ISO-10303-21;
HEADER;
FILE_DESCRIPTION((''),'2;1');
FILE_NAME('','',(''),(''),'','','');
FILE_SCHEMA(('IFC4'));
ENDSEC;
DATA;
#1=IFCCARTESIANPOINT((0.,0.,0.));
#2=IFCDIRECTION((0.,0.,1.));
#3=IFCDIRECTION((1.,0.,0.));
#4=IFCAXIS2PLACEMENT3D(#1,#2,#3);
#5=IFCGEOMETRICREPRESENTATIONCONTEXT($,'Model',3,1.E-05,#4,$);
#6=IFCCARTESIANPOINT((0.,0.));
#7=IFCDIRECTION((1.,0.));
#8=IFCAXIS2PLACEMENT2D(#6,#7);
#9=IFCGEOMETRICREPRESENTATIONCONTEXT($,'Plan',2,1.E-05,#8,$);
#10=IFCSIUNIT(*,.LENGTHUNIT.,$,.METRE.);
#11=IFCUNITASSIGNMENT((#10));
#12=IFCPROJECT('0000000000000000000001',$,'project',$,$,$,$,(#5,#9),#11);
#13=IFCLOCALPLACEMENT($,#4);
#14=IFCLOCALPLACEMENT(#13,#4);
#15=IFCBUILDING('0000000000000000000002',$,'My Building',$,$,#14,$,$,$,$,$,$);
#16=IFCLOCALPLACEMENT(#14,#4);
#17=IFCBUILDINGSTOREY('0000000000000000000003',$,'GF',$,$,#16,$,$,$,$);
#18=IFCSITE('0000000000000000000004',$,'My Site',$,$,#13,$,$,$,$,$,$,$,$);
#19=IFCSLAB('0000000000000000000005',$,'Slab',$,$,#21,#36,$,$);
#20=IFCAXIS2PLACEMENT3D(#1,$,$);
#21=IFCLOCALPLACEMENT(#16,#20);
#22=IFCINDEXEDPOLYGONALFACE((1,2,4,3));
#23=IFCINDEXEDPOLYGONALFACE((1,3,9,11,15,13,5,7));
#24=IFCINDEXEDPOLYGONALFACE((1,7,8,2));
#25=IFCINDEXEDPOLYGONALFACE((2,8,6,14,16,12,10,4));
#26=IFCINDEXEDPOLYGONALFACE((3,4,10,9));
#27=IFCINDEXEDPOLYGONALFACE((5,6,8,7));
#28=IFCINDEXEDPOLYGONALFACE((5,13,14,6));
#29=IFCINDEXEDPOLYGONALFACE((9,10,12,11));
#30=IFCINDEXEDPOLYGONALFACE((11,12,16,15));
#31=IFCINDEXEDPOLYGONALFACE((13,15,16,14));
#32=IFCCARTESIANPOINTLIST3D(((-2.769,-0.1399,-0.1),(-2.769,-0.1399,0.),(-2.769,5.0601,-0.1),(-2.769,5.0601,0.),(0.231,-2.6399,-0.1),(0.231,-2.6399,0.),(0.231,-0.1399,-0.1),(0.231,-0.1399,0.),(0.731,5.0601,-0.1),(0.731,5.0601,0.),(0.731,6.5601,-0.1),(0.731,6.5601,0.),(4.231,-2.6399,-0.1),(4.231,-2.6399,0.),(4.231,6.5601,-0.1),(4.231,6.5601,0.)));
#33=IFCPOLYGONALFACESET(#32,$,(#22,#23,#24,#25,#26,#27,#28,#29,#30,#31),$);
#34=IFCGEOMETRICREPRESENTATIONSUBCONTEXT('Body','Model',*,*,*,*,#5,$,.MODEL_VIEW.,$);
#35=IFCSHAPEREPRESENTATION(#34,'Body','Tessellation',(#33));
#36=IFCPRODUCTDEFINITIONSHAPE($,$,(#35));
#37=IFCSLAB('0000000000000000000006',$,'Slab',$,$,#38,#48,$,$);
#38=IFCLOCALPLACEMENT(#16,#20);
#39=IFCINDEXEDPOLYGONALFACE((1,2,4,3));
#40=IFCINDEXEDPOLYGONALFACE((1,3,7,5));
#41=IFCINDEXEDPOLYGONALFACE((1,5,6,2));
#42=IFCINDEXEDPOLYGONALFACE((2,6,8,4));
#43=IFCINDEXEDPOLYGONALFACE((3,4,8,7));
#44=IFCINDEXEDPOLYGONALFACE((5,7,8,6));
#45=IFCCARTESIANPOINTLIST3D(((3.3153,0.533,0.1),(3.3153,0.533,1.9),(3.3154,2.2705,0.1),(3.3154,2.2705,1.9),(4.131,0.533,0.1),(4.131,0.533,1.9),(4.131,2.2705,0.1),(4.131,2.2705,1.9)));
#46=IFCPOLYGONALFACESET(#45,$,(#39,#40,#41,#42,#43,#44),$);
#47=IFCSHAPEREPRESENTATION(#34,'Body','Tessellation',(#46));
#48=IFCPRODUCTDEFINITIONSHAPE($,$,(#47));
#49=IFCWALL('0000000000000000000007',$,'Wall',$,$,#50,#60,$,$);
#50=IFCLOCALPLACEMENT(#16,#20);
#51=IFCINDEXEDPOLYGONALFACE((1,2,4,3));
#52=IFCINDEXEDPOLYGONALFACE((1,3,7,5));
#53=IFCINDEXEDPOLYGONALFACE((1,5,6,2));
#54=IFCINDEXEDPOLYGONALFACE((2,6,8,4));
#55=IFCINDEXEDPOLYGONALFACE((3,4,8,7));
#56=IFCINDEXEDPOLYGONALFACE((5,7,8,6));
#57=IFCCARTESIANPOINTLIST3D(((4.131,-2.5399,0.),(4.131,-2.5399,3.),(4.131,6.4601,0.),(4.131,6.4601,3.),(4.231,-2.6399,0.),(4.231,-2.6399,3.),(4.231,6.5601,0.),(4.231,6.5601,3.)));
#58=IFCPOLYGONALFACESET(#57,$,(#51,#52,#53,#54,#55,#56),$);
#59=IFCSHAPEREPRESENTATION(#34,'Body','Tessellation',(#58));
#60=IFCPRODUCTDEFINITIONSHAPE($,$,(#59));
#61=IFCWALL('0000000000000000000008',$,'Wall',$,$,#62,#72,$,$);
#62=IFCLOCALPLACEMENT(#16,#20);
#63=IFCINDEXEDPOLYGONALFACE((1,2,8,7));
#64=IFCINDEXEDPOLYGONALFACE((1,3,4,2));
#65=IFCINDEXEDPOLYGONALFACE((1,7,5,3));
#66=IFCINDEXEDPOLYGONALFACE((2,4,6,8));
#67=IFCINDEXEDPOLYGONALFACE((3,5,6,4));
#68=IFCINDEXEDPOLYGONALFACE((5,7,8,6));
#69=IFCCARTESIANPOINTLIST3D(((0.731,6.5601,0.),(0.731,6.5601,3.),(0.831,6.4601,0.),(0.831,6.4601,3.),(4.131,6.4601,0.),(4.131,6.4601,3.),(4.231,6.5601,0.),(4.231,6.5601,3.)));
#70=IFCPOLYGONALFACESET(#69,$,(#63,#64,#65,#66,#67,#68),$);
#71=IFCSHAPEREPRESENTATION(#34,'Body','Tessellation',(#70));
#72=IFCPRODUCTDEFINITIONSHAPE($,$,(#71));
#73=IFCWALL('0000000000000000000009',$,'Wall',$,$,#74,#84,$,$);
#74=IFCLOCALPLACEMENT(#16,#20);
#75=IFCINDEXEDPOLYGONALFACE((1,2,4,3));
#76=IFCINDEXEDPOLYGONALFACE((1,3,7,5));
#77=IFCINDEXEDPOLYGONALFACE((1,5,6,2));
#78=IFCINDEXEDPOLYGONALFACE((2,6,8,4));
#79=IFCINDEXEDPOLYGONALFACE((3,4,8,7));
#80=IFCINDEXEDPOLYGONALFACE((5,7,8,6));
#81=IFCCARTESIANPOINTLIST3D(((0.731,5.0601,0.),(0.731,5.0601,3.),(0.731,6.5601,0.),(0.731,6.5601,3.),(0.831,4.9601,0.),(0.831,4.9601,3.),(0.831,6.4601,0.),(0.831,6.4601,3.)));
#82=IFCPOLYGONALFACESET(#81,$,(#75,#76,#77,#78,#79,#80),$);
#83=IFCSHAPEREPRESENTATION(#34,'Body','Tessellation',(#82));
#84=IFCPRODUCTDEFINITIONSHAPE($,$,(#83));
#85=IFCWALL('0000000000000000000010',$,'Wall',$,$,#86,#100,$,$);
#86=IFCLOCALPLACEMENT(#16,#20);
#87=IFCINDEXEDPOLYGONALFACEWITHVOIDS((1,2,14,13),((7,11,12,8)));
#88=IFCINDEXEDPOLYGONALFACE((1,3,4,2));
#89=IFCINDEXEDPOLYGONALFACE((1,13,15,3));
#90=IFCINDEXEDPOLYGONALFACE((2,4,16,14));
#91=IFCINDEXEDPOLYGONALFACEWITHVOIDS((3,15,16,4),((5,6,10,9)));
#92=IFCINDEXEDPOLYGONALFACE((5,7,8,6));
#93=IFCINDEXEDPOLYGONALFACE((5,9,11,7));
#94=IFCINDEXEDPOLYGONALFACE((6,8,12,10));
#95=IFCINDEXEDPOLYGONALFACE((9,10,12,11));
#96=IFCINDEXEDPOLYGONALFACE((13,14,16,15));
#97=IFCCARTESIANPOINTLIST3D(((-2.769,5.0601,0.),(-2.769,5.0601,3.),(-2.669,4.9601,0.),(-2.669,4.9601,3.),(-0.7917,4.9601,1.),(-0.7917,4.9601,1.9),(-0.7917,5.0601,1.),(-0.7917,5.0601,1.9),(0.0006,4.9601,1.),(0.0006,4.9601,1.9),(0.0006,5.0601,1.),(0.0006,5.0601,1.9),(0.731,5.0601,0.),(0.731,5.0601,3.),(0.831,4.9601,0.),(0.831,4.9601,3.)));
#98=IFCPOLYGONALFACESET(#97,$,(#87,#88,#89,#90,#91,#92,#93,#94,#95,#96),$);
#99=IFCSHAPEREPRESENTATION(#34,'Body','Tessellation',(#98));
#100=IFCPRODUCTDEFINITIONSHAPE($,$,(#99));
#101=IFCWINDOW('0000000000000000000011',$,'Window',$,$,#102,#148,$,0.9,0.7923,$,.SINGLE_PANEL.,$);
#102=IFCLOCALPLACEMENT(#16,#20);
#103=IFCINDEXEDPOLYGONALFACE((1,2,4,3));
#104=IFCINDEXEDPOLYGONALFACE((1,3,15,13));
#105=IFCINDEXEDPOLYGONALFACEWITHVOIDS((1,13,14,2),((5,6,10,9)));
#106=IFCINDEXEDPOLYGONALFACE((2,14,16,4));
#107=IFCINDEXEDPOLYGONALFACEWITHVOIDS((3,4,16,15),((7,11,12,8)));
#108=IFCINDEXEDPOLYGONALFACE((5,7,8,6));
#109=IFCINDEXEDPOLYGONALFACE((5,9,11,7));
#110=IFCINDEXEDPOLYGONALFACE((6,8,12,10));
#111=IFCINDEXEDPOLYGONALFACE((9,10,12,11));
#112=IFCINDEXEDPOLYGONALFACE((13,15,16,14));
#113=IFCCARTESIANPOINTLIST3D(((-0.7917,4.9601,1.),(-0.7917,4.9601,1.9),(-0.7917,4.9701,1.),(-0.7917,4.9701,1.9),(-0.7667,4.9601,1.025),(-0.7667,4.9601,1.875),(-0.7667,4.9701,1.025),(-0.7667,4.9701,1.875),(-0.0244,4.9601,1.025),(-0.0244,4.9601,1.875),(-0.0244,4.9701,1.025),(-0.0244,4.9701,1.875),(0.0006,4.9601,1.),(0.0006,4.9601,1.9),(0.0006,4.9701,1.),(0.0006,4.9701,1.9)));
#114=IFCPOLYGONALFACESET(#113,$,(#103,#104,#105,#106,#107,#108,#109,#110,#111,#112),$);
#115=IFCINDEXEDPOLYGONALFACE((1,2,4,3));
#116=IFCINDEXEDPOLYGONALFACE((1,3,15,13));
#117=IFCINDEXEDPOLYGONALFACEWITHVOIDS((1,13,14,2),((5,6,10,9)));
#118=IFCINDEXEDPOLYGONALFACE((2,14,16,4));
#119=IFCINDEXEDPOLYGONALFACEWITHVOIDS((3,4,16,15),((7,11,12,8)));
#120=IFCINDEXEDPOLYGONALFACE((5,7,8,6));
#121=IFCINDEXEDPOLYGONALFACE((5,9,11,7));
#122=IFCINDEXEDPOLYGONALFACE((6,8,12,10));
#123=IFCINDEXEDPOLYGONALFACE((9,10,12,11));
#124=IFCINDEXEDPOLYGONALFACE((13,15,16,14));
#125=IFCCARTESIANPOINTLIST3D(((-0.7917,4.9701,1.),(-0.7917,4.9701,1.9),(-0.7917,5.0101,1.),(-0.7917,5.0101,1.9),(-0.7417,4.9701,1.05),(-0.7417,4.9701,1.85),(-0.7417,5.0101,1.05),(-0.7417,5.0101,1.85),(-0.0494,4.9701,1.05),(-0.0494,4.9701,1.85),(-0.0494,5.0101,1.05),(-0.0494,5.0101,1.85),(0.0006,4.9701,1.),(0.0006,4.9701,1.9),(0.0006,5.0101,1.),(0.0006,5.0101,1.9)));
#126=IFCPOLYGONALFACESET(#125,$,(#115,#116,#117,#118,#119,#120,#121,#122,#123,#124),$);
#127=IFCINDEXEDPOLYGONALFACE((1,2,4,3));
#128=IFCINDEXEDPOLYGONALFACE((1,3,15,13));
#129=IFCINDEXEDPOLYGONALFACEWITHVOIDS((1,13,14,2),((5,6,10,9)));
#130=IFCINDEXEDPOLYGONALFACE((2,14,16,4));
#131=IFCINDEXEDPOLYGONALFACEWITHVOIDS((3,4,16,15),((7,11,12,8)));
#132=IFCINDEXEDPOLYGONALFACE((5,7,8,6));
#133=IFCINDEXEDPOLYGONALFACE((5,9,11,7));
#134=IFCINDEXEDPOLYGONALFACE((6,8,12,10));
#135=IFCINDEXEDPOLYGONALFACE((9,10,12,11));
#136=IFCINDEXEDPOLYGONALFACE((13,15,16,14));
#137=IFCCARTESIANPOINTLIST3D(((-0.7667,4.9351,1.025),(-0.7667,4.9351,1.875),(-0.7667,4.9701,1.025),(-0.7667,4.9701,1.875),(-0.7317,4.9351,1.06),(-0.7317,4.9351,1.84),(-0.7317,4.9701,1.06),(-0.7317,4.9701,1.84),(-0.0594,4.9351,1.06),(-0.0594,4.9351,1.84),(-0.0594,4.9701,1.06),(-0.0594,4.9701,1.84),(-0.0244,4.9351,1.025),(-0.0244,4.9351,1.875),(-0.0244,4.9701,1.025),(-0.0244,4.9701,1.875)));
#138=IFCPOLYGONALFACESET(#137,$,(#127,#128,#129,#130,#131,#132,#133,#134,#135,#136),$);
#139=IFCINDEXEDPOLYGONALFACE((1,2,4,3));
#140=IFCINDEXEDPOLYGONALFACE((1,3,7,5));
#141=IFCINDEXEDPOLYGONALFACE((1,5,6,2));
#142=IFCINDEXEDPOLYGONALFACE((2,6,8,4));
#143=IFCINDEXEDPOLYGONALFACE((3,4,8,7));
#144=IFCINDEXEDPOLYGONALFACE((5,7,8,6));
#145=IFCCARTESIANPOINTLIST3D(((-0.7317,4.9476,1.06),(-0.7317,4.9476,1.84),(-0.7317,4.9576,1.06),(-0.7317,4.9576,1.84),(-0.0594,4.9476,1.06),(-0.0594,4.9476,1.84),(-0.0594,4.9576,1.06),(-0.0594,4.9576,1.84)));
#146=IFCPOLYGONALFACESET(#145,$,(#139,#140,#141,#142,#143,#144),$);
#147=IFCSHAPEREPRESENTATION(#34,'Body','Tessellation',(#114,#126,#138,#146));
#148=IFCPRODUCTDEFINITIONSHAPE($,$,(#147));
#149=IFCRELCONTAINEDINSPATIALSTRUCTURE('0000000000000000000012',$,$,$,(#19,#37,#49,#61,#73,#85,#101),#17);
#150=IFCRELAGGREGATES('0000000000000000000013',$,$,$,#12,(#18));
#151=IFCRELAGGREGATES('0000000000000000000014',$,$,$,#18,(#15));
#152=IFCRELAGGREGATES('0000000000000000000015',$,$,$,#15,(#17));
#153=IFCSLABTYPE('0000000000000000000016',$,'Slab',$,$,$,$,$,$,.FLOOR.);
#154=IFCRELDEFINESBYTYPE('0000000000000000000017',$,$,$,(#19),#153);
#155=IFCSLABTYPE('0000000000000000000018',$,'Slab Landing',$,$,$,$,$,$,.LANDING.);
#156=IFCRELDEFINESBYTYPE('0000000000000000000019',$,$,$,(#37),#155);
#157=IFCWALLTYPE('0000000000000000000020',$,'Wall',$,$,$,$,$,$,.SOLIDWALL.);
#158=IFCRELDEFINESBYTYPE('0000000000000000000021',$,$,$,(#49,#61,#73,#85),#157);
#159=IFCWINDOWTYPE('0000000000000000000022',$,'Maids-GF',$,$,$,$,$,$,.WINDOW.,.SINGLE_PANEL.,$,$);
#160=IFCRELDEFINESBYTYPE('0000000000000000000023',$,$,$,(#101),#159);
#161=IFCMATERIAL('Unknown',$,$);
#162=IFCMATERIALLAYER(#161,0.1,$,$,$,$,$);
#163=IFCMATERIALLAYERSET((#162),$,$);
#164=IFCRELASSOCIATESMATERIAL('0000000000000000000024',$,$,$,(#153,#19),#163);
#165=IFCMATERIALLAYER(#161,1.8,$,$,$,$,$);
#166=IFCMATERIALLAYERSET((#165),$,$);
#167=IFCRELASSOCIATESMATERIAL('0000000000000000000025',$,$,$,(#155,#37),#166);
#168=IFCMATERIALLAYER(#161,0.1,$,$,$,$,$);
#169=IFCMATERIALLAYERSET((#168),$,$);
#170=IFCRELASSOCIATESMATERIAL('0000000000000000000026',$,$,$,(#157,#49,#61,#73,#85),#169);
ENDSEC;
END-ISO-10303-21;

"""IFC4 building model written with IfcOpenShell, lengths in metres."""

from ifc_helpers import new_model, entity, si_unit, frame, origin_with_axes, origin_2d_with_axis, place, context, subcontext, project, spatial, line, indexed_curve, outline, extrude, shape, source, transform, mapped, material, layer, layer_set, layer_usage, type_object, type_shapes, element, fill, save


model = new_model("IFC4")

# Units and contexts
model_context = context("Model", 3, precision=1e-05, world=origin_with_axes())
plan_context = context("Plan", 2, precision=1e-05, world=origin_2d_with_axis())
body_context_1 = subcontext(model_context, "Body", "Model", "MODEL_VIEW")
body_context_2 = subcontext(plan_context, "Body", "Plan", "PLAN_VIEW")
ifc_project = project(units=[si_unit("LENGTHUNIT", "METRE")], contexts=[model_context, plan_context])

# Site, building, storey
site_placement = place(None, origin_with_axes())
site = spatial("IfcSite", under=ifc_project, at=site_placement, Name="My Site")
building_placement = place(site_placement, origin_with_axes())
building = spatial("IfcBuilding", under=site, at=building_placement, Name="My Building")
storey_placement = place(building_placement, origin_with_axes())
storey = spatial("IfcBuildingStorey", under=building, at=storey_placement, Name="GF")

# Slabs
ifc_material_1 = material(Name="Unknown")
ifc_layer_1 = layer(ifc_material_1, 0.1)
ifc_layer_set_1 = layer_set([ifc_layer_1])
ifc_layer_usage_1 = layer_usage(ifc_layer_set_1, "AXIS3", "POSITIVE", -0.1)
slab_type_1 = type_object("IfcSlabType", Name="Slab", PredefinedType="FLOOR", material=ifc_layer_set_1)
slab_1_placement = place(storey_placement, frame((4.231, 6.5601, 0.0), z_axis=(0.0, 0.0, 1.0), x_axis=(1.0, 0.0, 0.0)))
element("IfcSlab", 1, at=slab_1_placement, inside=storey, type_object=slab_type_1, material=ifc_layer_usage_1, Name="Slab", context=body_context_1, shape_type="SweptSolid", body=[
    extrude(outline(indexed_curve([(0.0, 0.0), (-3.5, 0.0), (-3.5, -1.5), (-7.0, -1.5), (-7.0, -6.7), (-4.0, -6.7), (-4.0, -9.2), (0.0, -9.2), (0.0, 0.0)])), frame((0.0, 0.0, -0.1), z_axis=(0.0, 0.0, 1.0), x_axis=(1.0, 0.0, 0.0)), (0.0, 0.0, 1.0), 0.1),
])
ifc_layer_2 = layer(ifc_material_1, 1.8)
ifc_layer_set_2 = layer_set([ifc_layer_2])
ifc_layer_usage_2 = layer_usage(ifc_layer_set_2, "AXIS3", "POSITIVE", -0.1)
slab_type_2 = type_object("IfcSlabType", Name="Slab Landing", PredefinedType="LANDING", material=ifc_layer_set_2)
slab_2_placement = place(storey_placement, frame((3.3153, 0.533, 0.2), z_axis=(0.0, 0.0, 1.0), x_axis=(1.0, 0.0, 0.0)))
element("IfcSlab", 2, at=slab_2_placement, inside=storey, type_object=slab_type_2, material=ifc_layer_usage_2, Name="Slab", context=body_context_1, shape_type="SweptSolid", body=[
    extrude(outline(indexed_curve([(0.0, 1.7375), (0.8156, 1.7375), (0.8156, 0.0), (0.0, 0.0), (0.0, 1.7375)])), frame((0.0, 0.0, -0.1), z_axis=(0.0, 0.0, 1.0), x_axis=(1.0, 0.0, 0.0)), (0.0, 0.0, 1.0), 1.8),
])

# Shared definitions
ifc_layer_3 = layer(ifc_material_1, 0.1)
ifc_layer_set_3 = layer_set([ifc_layer_3])
wall_type = type_object("IfcWallType", Name="Wall", PredefinedType="SOLIDWALL", material=ifc_layer_set_3)

# Walls
ifc_layer_usage_3 = layer_usage(ifc_layer_set_3, "AXIS2", "POSITIVE", 0.0)
wall_1_placement = place(storey_placement, frame((4.231, -2.6399, 0.0), z_axis=(0.0, 0.0, 1.0), x_axis=(0.0, 1.0, 0.0)))
element("IfcWall", 3, at=wall_1_placement, inside=storey, type_object=wall_type, material=ifc_layer_usage_3, Name="Wall", context=body_context_1, shape_type="SweptSolid", body=[
    extrude(outline(indexed_curve([(0.0, 0.0), (0.1, 0.1), (9.1, 0.1), (9.2, 0.0)], segments=[line(1, 2, 3, 4, 1)])), origin_with_axes(), (0.0, 0.0, 1.0), 3.0),
])
ifc_layer_usage_4 = layer_usage(ifc_layer_set_3, "AXIS2", "POSITIVE", 0.0)
wall_2_placement = place(storey_placement, frame((4.231, 6.5601, 0.0), z_axis=(0.0, 0.0, 1.0), x_axis=(-1.0, 0.0, 0.0)))
element("IfcWall", 4, at=wall_2_placement, inside=storey, type_object=wall_type, material=ifc_layer_usage_4, Name="Wall", context=body_context_1, shape_type="SweptSolid", body=[
    extrude(outline(indexed_curve([(0.0, 0.0), (0.1, 0.1), (3.4, 0.1), (3.5, 0.0)], segments=[line(1, 2, 3, 4, 1)])), origin_with_axes(), (0.0, 0.0, 1.0), 3.0),
])
ifc_layer_usage_5 = layer_usage(ifc_layer_set_3, "AXIS2", "POSITIVE", 0.0)
wall_3_placement = place(storey_placement, frame((0.731, 6.5601, 0.0), z_axis=(0.0, 0.0, 1.0), x_axis=(0.0, -1.0, 0.0)))
element("IfcWall", 5, at=wall_3_placement, inside=storey, type_object=wall_type, material=ifc_layer_usage_5, Name="Wall", context=body_context_1, shape_type="SweptSolid", body=[
    extrude(outline(indexed_curve([(0.0, 0.0), (0.1, 0.1), (1.6, 0.1), (1.5, 0.0)], segments=[line(1, 2, 3, 4, 1)])), origin_with_axes(), (0.0, 0.0, 1.0), 3.0),
])

# Wall, opening, window
ifc_layer_usage_6 = layer_usage(ifc_layer_set_3, "AXIS2", "POSITIVE", 0.0)
wall_4_placement = place(storey_placement, frame((0.731, 5.0601, 0.0), z_axis=(0.0, 0.0, 1.0), x_axis=(-1.0, 0.0, 0.0)))
wall_4 = element("IfcWall", 6, at=wall_4_placement, inside=storey, type_object=wall_type, material=ifc_layer_usage_6, Name="Wall", context=body_context_1, shape_type="SweptSolid", body=[
    extrude(outline(indexed_curve([(0.0, 0.0), (-0.1, 0.1), (3.4, 0.1), (3.5, 0.0)], segments=[line(1, 2, 3, 4, 1)])), origin_with_axes(), (0.0, 0.0, 1.0), 3.0),
])
shared_shape_1 = source(origin_with_axes(), body_context_1, "Body", "SweptSolid", [
    extrude(outline(indexed_curve([(0.0, 0.0), (0.7923, 0.0), (0.7923, 0.9), (0.0, 0.9)], segments=[line(1, 2, 3, 4, 1)])), frame((0.0, -0.6, 0.0), z_axis=(0.0, -1.0, 0.0), x_axis=(1.0, 0.0, 0.0)), (0.0, 0.0, -1.0), 1.2),
])
opening_1_placement = place(wall_4_placement, frame((0.7304, 0.0, 1.0), z_axis=(0.0, 0.0, 1.0), x_axis=(1.0, 0.0, 0.0)))
opening_1 = element("IfcOpeningElement", 7, at=opening_1_placement, cuts=wall_4, PredefinedType="OPENING", context=body_context_1, shape_type="MappedRepresentation", body=[
    mapped(shared_shape_1, transform((0.0, 0.0, 0.0), x_axis=(1.0, 0.0, 0.0), y_axis=(0.0, 1.0, 0.0), z_axis=(0.0, 0.0, 1.0), scale=1.0)),
])
window_type_1 = type_object("IfcWindowType", Name="Maids-GF", PartitioningType="SINGLE_PANEL", PredefinedType="WINDOW")
shared_shape_2 = source(origin_with_axes(), body_context_1, "Body", "SweptSolid", [
    extrude(outline(indexed_curve([(0.0, 0.0), (0.7923, 0.0), (0.7923, 0.9), (0.0, 0.9)], segments=[line(1, 2, 3, 4, 1)]), holes=[indexed_curve([(0.025, 0.025), (0.7673, 0.025), (0.7673, 0.875), (0.025, 0.875)], segments=[line(1, 2, 3, 4, 1)])]), frame((0.0, 0.09, 0.0), z_axis=(0.0, -1.0, 0.0), x_axis=(1.0, 0.0, 0.0)), (0.0, 0.0, -1.0), 0.01),
    extrude(outline(indexed_curve([(0.0, 0.0), (0.7923, 0.0), (0.7923, 0.9), (0.0, 0.9)], segments=[line(1, 2, 3, 4, 1)]), holes=[indexed_curve([(0.05, 0.05), (0.7423, 0.05), (0.7423, 0.85), (0.05, 0.85)], segments=[line(1, 2, 3, 4, 1)])]), frame((0.0, 0.05, 0.0), z_axis=(0.0, -1.0, 0.0), x_axis=(1.0, 0.0, 0.0)), (0.0, 0.0, -1.0), 0.04),
    extrude(outline(indexed_curve([(0.0, 0.0), (0.7423, 0.0), (0.7423, 0.85), (0.0, 0.85)], segments=[line(1, 2, 3, 4, 1)]), holes=[indexed_curve([(0.035, 0.035), (0.7073, 0.035), (0.7073, 0.815), (0.035, 0.815)], segments=[line(1, 2, 3, 4, 1)])]), frame((0.025, 0.09, 0.025), z_axis=(0.0, -1.0, 0.0), x_axis=(1.0, 0.0, 0.0)), (0.0, 0.0, -1.0), 0.035),
    extrude(outline(indexed_curve([(0.035, 0.035), (0.7073, 0.035), (0.7073, 0.815), (0.035, 0.815)], segments=[line(1, 2, 3, 4, 1)])), frame((0.025, 0.1025, 0.025), z_axis=(0.0, -1.0, 0.0), x_axis=(1.0, 0.0, 0.0)), (0.0, 0.0, -1.0), 0.01),
])
shared_shape_3 = source(origin_with_axes(), body_context_2, "Body", "Curve2D", [
    entity("IfcIndexedPolyCurve", entity("IfcCartesianPointList2D", [[0.05, 0.05], [0.7423, 0.05]])),
    entity("IfcIndexedPolyCurve", entity("IfcCartesianPointList2D", [[0.0, 0.1], [0.025, 0.1], [0.025, 0.09], [0.05, 0.09], [0.05, 0.05], [0.0, 0.05]]), [entity("IfcLineIndex", [1, 2, 3, 4, 5, 6, 1])]),
    entity("IfcIndexedPolyCurve", entity("IfcCartesianPointList2D", [[0.7923, 0.1], [0.7673, 0.1], [0.7673, 0.09], [0.7423, 0.09], [0.7423, 0.05], [0.7923, 0.05]]), [entity("IfcLineIndex", [1, 2, 3, 4, 5, 6, 1])]),
    entity("IfcIndexedPolyCurve", entity("IfcCartesianPointList2D", [[0.025, 0.09], [0.06, 0.09], [0.06, 0.125], [0.025, 0.125]]), [entity("IfcLineIndex", [1, 2, 3, 4, 1])]),
    entity("IfcIndexedPolyCurve", entity("IfcCartesianPointList2D", [[0.7673, 0.09], [0.7323, 0.09], [0.7323, 0.125], [0.7673, 0.125]]), [entity("IfcLineIndex", [1, 2, 3, 4, 1])]),
    entity("IfcIndexedPolyCurve", entity("IfcCartesianPointList2D", [[0.06, 0.09], [0.7323, 0.09]])),
    entity("IfcIndexedPolyCurve", entity("IfcCartesianPointList2D", [[0.06, 0.125], [0.7323, 0.125]])),
    entity("IfcIndexedPolyCurve", entity("IfcCartesianPointList2D", [[0.06, 0.1075], [0.7323, 0.1075]])),
])
type_shapes(window_type_1, [shared_shape_2, shared_shape_3])
window_1_placement = place(opening_1_placement, frame((0.0, 0.0, 0.0), z_axis=(0.0, 0.0, 1.0), x_axis=(1.0, 0.0, 0.0)))
window_1 = element("IfcWindow", 8, at=window_1_placement, inside=storey, type_object=window_type_1, Name="Window", OverallHeight=0.9, OverallWidth=0.7923, PartitioningType="SINGLE_PANEL", shapes=[
    shape(body_context_1, "Body", "MappedRepresentation", [mapped(shared_shape_2, transform((0.0, 0.0, 0.0), x_axis=(1.0, 0.0, 0.0), y_axis=(0.0, 1.0, 0.0), z_axis=(0.0, 0.0, 1.0), scale=1.0))]),
    shape(body_context_2, "Body", "MappedRepresentation", [mapped(shared_shape_3, transform((0.0, 0.0, 0.0), x_axis=(1.0, 0.0, 0.0), y_axis=(0.0, 1.0, 0.0), z_axis=(0.0, 0.0, 1.0), scale=1.0))]),
])
fill(opening_1, window_1)

save(model, "model.ifc")
